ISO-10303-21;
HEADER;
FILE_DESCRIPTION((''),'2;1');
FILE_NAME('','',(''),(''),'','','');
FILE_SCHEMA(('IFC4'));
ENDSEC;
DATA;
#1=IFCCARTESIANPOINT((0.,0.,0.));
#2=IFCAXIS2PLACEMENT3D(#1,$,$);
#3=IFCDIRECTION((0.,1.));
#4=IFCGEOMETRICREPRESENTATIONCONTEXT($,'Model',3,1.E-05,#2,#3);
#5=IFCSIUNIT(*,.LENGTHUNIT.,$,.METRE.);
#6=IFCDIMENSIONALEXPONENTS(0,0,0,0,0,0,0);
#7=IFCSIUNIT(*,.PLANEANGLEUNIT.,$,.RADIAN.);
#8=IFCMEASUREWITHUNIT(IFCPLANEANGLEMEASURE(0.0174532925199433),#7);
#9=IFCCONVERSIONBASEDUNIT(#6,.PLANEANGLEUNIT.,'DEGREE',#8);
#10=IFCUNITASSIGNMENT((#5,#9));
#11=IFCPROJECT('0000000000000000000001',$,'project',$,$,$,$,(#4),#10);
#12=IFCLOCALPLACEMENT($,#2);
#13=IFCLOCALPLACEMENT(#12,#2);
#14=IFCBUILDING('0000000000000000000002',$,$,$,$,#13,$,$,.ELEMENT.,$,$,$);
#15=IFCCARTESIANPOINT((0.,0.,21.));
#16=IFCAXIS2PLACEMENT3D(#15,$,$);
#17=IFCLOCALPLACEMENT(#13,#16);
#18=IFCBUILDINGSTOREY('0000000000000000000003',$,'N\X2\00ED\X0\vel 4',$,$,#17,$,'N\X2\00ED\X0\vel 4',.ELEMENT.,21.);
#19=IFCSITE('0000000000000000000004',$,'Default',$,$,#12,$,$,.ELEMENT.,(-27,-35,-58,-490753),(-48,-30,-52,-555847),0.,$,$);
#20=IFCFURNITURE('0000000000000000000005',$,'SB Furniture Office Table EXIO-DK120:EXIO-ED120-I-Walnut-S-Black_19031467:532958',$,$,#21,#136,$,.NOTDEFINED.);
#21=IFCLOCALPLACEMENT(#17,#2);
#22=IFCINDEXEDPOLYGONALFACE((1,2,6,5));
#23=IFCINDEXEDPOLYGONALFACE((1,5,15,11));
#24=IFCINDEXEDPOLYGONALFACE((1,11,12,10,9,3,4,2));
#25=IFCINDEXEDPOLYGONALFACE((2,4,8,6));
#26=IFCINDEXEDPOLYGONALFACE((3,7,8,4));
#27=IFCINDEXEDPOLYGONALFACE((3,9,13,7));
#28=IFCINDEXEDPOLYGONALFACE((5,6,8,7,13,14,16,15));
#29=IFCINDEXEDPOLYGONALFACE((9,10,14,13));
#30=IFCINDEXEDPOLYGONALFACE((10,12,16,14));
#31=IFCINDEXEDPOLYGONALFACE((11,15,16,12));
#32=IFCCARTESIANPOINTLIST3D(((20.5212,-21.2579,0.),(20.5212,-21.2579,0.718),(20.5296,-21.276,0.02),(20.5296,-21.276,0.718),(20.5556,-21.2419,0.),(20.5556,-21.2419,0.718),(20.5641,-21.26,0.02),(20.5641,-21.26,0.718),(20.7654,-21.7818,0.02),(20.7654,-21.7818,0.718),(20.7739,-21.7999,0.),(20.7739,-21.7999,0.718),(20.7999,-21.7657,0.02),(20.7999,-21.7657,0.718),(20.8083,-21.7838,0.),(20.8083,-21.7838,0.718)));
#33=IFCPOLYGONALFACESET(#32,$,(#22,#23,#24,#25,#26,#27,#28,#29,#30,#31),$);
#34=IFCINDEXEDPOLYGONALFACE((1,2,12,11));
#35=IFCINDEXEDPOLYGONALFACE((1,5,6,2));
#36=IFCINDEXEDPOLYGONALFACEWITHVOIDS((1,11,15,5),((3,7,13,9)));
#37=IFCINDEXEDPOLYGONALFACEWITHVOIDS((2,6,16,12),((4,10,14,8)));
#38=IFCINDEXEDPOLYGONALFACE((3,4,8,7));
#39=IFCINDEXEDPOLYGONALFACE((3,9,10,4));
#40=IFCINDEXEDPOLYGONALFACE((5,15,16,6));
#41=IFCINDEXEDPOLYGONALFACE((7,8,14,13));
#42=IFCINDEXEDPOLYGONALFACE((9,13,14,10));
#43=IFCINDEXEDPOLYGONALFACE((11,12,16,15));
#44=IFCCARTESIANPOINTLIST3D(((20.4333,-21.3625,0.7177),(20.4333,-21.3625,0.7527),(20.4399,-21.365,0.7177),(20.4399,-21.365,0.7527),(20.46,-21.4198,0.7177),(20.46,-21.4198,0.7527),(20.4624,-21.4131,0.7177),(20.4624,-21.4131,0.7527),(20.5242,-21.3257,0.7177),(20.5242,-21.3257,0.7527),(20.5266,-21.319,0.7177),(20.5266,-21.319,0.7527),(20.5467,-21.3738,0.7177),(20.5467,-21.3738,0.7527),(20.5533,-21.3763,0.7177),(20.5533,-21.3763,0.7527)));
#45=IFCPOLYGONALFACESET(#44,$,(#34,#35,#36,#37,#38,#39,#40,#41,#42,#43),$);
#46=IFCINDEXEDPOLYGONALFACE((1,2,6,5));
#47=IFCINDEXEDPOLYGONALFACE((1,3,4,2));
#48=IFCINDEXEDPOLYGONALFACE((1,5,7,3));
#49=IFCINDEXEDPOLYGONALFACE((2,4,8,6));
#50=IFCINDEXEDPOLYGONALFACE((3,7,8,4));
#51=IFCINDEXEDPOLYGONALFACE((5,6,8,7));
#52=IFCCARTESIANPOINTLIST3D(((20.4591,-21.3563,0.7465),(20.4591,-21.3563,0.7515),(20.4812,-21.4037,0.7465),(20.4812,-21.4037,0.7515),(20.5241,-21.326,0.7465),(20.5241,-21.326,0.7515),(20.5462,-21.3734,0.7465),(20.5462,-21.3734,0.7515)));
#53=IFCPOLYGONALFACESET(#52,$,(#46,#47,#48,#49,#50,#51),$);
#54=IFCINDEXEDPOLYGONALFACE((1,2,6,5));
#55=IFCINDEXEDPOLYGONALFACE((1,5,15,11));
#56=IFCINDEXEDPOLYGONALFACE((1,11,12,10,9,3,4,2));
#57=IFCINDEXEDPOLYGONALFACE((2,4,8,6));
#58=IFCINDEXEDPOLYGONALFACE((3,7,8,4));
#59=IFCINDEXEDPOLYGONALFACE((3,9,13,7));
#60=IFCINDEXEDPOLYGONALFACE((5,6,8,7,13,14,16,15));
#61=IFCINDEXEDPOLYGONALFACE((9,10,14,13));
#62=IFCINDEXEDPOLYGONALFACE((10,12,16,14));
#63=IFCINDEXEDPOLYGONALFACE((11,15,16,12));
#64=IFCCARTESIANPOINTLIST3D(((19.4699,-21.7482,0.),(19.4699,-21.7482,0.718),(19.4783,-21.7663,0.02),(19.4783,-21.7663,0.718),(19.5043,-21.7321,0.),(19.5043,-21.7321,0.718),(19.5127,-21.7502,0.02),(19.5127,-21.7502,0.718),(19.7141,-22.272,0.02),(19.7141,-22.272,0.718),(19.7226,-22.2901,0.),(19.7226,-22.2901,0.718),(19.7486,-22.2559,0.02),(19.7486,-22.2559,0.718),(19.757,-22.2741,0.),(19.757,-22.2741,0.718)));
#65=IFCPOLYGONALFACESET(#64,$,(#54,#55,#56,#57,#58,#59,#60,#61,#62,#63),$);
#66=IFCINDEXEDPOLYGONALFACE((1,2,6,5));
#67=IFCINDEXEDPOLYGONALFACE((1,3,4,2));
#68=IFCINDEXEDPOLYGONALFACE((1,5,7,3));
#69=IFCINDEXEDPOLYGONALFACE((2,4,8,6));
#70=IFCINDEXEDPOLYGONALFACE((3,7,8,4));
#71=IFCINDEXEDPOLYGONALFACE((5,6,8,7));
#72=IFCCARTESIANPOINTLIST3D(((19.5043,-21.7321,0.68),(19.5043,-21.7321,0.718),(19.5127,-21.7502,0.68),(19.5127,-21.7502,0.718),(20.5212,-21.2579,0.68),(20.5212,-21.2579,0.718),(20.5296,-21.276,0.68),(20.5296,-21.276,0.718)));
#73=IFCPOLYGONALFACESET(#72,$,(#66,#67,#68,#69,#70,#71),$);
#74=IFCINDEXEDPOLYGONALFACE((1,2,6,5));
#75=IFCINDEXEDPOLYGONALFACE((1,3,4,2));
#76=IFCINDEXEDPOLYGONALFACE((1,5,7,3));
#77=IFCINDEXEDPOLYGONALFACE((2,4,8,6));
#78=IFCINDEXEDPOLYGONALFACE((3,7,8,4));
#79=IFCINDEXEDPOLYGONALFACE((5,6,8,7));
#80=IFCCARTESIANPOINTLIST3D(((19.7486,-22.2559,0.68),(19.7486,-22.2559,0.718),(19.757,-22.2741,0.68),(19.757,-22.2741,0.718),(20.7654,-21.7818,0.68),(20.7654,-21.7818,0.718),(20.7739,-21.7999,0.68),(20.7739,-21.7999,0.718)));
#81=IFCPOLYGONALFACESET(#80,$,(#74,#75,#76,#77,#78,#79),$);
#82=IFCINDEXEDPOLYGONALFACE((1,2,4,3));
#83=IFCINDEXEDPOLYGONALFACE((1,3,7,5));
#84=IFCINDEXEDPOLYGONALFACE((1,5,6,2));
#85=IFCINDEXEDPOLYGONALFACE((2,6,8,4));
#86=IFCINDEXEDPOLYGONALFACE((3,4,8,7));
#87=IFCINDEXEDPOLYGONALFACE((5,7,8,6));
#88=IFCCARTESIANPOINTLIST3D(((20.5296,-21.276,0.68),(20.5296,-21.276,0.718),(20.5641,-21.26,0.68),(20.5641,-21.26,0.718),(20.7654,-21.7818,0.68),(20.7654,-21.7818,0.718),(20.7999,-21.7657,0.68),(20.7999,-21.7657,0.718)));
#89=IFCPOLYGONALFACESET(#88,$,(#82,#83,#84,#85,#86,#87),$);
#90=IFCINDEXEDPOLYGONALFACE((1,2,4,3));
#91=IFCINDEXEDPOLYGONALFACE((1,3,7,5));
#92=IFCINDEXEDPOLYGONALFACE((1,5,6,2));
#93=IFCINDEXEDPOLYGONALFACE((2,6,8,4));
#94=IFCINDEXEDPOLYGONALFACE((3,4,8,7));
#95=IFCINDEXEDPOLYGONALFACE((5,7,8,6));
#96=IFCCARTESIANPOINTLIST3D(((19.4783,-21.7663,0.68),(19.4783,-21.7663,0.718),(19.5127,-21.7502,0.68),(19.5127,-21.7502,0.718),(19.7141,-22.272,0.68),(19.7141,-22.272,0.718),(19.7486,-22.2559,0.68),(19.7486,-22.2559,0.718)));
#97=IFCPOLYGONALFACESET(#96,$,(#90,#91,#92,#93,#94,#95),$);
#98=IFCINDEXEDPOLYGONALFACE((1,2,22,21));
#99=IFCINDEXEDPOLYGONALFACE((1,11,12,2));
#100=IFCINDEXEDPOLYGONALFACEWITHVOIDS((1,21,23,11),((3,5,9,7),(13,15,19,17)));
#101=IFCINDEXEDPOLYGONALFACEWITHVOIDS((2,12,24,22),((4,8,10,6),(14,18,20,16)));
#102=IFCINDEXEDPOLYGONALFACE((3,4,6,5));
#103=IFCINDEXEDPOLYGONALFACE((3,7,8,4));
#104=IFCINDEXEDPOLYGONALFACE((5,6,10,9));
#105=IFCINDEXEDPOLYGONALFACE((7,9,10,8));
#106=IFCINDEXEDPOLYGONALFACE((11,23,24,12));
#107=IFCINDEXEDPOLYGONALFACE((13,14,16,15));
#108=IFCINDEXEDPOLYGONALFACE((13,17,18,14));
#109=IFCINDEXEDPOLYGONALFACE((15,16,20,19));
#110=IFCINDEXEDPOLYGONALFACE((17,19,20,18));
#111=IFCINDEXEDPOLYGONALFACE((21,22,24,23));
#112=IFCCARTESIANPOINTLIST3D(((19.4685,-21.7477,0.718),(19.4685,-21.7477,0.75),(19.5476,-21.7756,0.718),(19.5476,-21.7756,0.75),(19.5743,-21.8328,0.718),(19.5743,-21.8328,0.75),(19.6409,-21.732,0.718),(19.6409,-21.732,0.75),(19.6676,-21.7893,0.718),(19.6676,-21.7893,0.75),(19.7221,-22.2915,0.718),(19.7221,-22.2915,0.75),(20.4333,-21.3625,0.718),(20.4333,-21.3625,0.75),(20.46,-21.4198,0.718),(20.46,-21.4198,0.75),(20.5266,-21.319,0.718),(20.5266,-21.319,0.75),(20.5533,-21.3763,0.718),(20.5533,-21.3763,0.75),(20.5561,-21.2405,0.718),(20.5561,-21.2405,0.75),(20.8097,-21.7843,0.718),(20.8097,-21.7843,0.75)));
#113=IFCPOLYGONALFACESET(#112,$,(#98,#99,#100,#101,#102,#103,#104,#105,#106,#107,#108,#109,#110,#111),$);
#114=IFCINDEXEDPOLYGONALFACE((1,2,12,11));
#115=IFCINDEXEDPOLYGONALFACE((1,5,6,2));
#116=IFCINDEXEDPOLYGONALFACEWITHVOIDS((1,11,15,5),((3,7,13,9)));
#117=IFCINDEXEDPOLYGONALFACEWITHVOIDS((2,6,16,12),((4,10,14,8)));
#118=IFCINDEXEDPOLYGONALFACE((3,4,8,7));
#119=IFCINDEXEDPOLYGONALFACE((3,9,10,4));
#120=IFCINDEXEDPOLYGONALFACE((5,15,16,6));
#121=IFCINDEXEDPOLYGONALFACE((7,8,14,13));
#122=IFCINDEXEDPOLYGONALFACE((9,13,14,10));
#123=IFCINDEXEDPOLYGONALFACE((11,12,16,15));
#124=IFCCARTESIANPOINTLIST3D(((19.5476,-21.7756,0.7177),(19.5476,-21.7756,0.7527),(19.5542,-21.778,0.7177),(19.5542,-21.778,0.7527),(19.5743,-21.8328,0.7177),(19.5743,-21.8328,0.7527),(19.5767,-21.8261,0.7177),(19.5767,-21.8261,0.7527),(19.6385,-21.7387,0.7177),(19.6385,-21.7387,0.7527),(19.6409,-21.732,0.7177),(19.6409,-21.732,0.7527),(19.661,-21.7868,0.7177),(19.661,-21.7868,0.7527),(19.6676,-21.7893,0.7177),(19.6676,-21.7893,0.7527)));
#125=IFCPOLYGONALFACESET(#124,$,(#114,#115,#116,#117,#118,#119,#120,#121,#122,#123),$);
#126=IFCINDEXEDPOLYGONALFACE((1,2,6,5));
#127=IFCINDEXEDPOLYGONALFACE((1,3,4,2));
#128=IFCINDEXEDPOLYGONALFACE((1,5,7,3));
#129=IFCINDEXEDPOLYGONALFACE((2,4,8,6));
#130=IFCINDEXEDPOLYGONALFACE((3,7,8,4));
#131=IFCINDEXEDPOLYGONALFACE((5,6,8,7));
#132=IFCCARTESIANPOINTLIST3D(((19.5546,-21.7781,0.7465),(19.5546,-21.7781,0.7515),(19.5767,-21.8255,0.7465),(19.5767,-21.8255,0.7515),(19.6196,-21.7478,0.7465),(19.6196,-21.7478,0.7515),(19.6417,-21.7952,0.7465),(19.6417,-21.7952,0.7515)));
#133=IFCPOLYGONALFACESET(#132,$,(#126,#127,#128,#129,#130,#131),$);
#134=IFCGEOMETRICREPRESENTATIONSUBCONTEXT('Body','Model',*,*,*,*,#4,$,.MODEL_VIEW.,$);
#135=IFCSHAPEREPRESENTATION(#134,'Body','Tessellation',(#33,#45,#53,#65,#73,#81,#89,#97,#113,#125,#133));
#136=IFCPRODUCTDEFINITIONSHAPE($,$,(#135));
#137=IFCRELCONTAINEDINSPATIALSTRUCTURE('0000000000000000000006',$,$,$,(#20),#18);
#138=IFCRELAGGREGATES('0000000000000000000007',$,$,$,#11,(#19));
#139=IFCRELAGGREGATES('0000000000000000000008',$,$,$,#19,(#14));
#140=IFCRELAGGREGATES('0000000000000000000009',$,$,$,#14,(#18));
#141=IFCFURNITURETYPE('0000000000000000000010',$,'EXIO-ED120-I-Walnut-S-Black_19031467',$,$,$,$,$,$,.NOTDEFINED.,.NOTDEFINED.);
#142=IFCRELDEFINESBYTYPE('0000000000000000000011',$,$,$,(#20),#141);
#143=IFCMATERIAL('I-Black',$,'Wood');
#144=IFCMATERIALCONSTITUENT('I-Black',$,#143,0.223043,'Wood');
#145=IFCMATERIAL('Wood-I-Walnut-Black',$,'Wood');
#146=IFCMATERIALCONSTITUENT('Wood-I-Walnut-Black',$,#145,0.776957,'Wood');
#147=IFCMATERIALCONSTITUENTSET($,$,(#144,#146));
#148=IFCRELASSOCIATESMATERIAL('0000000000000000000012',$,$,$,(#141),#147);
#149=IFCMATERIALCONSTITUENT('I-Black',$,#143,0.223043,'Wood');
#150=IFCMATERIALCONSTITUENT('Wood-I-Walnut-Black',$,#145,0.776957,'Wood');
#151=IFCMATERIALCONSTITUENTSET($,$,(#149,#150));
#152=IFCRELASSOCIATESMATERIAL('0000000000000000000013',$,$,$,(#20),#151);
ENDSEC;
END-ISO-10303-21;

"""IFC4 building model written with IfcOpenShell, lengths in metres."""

from ifc_helpers import new_model, entity, si_unit, converted_unit, direction, frame, frame_2d, origin, origin_2d_with_axis, place, context, subcontext, project, spatial, polyline, rectangle, outline, extrude, source, transform, mapped, material, constituent, constituent_set, type_object, type_shapes, element, save


model = new_model("IFC4")

# Units and contexts
model_context = context("Model", 3, precision=1e-05, world=origin(), true_north=direction((0.0, 1.0)))
body_context = subcontext(model_context, "Body", "Model", "MODEL_VIEW")
ifc_project = project(units=[si_unit("LENGTHUNIT", "METRE"), converted_unit("PLANEANGLEUNIT", "DEGREE", entity("IfcPlaneAngleMeasure", 0.0174532925199433), si_unit("PLANEANGLEUNIT", "RADIAN"), dimensions=[0, 0, 0, 0, 0, 0, 0])], contexts=[model_context])

# Site, building, storey
site_placement = place(None, origin())
site = spatial("IfcSite", under=ifc_project, at=site_placement, Name="Default", CompositionType="ELEMENT", RefLatitude=(-27, -35, -58, -490753), RefLongitude=(-48, -30, -52, -555847), RefElevation=0.0)
building_placement = place(site_placement, origin())
building = spatial("IfcBuilding", under=site, at=building_placement, CompositionType="ELEMENT")
storey_placement = place(building_placement, frame((0.0, 0.0, 21.0)))
storey = spatial("IfcBuildingStorey", under=building, at=storey_placement, Name="Nível 4", LongName="Nível 4", CompositionType="ELEMENT", Elevation=21.0)

# Furniture
ifc_material_1 = material(Name="I-Black", Category="Wood")
ifc_material_2 = material(Name="Wood-I-Walnut-Black", Category="Wood")
ifc_constituent_1 = constituent(ifc_material_1, Name="I-Black", Category="Wood", fraction=0.223043)
ifc_constituent_2 = constituent(ifc_material_2, Name="Wood-I-Walnut-Black", Category="Wood", fraction=0.776957)
ifc_constituent_set_1 = constituent_set(constituents=[ifc_constituent_1, ifc_constituent_2])
furniture_type = type_object("IfcFurnitureType", Name="EXIO-ED120-I-Walnut-S-Black_19031467", AssemblyPlace="NOTDEFINED", PredefinedType="NOTDEFINED", material=ifc_constituent_set_1)
shared_shape_1 = source(origin(), body_context, "Body", "SweptSolid", [
    extrude(outline(polyline([(-0.354, -0.279), (-0.354, -0.299), (0.364, -0.299), (0.364, 0.299), (-0.354, 0.299), (-0.354, 0.279), (0.344, 0.279), (0.344, -0.279), (-0.354, -0.279)])), frame((0.561, 0.0, 0.364), z_axis=(-1.0, 0.0, 0.0), x_axis=(0.0, 0.0, -1.0)), (0.0, 0.0, -1.0), 0.038),
    extrude(outline(polyline([(-0.0316, -0.0515), (0.0316, -0.0515), (0.0316, 0.0515), (-0.0316, 0.0515), (-0.0316, -0.0515)]), holes=[polyline([(0.0266, -0.0465), (-0.0266, -0.0465), (-0.0266, 0.0465), (0.0266, 0.0465), (0.0266, -0.0465)])]), frame((0.4886, 0.2097, 0.7177), z_axis=(0.0, 0.0, 1.0), x_axis=(0.0, -1.0, 0.0)), (0.0, 0.0, 1.0), 0.035),
    extrude(rectangle(XDim=0.0717, YDim=0.0523, at=origin_2d_with_axis()), frame((0.499, 0.2099, 0.7465), z_axis=(0.0, 0.0, 1.0), x_axis=(-1.0, 0.0, 0.0)), (0.0, 0.0, 1.0), 0.005),
    extrude(outline(polyline([(-0.354, -0.279), (-0.354, -0.299), (0.364, -0.299), (0.364, 0.299), (-0.354, 0.299), (-0.354, 0.279), (0.344, 0.279), (0.344, -0.279), (-0.354, -0.279)])), frame((-0.599, 0.0, 0.364), z_axis=(-1.0, 0.0, 0.0), x_axis=(0.0, 0.0, -1.0)), (0.0, 0.0, -1.0), 0.038),
    extrude(rectangle(XDim=1.122, YDim=0.02, at=frame_2d((0.0, 0.0), x_axis=(1.0, 0.0))), frame((0.0, 0.289, 0.68), z_axis=(0.0, 0.0, 1.0), x_axis=(-1.0, 0.0, 0.0)), (0.0, 0.0, 1.0), 0.038),
    extrude(rectangle(XDim=1.122, YDim=0.02, at=origin_2d_with_axis()), frame((0.0, -0.289, 0.68), z_axis=(0.0, 0.0, 1.0), x_axis=(-1.0, 0.0, 0.0)), (0.0, 0.0, 1.0), 0.038),
    extrude(rectangle(XDim=0.038, YDim=0.558, at=frame_2d((0.0, 0.0), x_axis=(1.0, 0.0))), frame((0.58, 0.0, 0.68), z_axis=(0.0, 0.0, 1.0), x_axis=(-1.0, 0.0, 0.0)), (0.0, 0.0, 1.0), 0.038),
    extrude(rectangle(XDim=0.038, YDim=0.558, at=origin_2d_with_axis()), frame((-0.58, 0.0, 0.68), z_axis=(0.0, 0.0, 1.0), x_axis=(-1.0, 0.0, 0.0)), (0.0, 0.0, 1.0), 0.038),
    extrude(outline(polyline([(-0.6, -0.3), (0.6, -0.3), (0.6, 0.3), (-0.6, 0.3), (-0.6, -0.3)]), holes=[polyline([(0.4371, -0.2413), (0.4371, -0.1782), (0.5401, -0.1782), (0.5401, -0.2413), (0.4371, -0.2413)]), polyline([(-0.5401, -0.2413), (-0.5401, -0.1782), (-0.4371, -0.1782), (-0.4371, -0.2413), (-0.5401, -0.2413)])]), frame((0.0, 0.0, 0.718), z_axis=(0.0, 0.0, 1.0), x_axis=(-1.0, 0.0, 0.0)), (0.0, 0.0, 1.0), 0.032),
    extrude(outline(polyline([(-0.0316, -0.0515), (0.0316, -0.0515), (0.0316, 0.0515), (-0.0316, 0.0515), (-0.0316, -0.0515)]), holes=[polyline([(0.0266, -0.0465), (-0.0266, -0.0465), (-0.0266, 0.0465), (0.0266, 0.0465), (0.0266, -0.0465)])]), frame((-0.4886, 0.2097, 0.7177), z_axis=(0.0, 0.0, 1.0), x_axis=(0.0, 1.0, 0.0)), (0.0, 0.0, 1.0), 0.035),
    extrude(rectangle(XDim=0.0523, YDim=0.0717, at=origin_2d_with_axis()), frame((-0.499, 0.2099, 0.7465), z_axis=(0.0, 0.0, 1.0), x_axis=(0.0, -1.0, 0.0)), (0.0, 0.0, 1.0), 0.005),
])
type_shapes(furniture_type, [shared_shape_1])
ifc_constituent_3 = constituent(ifc_material_1, Name="I-Black", Category="Wood", fraction=0.223043)
ifc_constituent_4 = constituent(ifc_material_2, Name="Wood-I-Walnut-Black", Category="Wood", fraction=0.776957)
ifc_constituent_set_2 = constituent_set(constituents=[ifc_constituent_3, ifc_constituent_4])
furniture_1_placement = place(storey_placement, frame((20.1391, -21.766, 0.0), z_axis=(0.0, 0.0, 1.0), x_axis=(0.906308, 0.422618, 0.0)))
element("IfcFurniture", 1, at=furniture_1_placement, inside=storey, type_object=furniture_type, material=ifc_constituent_set_2, Name="SB Furniture Office Table EXIO-DK120:EXIO-ED120-I-Walnut-S-Black_19031467:532958", PredefinedType="NOTDEFINED", context=body_context, shape_type="MappedRepresentation", body=[
    mapped(shared_shape_1, transform((0.0, 0.0, 0.0), scale=1.0)),
])

save(model, "model.ifc")
